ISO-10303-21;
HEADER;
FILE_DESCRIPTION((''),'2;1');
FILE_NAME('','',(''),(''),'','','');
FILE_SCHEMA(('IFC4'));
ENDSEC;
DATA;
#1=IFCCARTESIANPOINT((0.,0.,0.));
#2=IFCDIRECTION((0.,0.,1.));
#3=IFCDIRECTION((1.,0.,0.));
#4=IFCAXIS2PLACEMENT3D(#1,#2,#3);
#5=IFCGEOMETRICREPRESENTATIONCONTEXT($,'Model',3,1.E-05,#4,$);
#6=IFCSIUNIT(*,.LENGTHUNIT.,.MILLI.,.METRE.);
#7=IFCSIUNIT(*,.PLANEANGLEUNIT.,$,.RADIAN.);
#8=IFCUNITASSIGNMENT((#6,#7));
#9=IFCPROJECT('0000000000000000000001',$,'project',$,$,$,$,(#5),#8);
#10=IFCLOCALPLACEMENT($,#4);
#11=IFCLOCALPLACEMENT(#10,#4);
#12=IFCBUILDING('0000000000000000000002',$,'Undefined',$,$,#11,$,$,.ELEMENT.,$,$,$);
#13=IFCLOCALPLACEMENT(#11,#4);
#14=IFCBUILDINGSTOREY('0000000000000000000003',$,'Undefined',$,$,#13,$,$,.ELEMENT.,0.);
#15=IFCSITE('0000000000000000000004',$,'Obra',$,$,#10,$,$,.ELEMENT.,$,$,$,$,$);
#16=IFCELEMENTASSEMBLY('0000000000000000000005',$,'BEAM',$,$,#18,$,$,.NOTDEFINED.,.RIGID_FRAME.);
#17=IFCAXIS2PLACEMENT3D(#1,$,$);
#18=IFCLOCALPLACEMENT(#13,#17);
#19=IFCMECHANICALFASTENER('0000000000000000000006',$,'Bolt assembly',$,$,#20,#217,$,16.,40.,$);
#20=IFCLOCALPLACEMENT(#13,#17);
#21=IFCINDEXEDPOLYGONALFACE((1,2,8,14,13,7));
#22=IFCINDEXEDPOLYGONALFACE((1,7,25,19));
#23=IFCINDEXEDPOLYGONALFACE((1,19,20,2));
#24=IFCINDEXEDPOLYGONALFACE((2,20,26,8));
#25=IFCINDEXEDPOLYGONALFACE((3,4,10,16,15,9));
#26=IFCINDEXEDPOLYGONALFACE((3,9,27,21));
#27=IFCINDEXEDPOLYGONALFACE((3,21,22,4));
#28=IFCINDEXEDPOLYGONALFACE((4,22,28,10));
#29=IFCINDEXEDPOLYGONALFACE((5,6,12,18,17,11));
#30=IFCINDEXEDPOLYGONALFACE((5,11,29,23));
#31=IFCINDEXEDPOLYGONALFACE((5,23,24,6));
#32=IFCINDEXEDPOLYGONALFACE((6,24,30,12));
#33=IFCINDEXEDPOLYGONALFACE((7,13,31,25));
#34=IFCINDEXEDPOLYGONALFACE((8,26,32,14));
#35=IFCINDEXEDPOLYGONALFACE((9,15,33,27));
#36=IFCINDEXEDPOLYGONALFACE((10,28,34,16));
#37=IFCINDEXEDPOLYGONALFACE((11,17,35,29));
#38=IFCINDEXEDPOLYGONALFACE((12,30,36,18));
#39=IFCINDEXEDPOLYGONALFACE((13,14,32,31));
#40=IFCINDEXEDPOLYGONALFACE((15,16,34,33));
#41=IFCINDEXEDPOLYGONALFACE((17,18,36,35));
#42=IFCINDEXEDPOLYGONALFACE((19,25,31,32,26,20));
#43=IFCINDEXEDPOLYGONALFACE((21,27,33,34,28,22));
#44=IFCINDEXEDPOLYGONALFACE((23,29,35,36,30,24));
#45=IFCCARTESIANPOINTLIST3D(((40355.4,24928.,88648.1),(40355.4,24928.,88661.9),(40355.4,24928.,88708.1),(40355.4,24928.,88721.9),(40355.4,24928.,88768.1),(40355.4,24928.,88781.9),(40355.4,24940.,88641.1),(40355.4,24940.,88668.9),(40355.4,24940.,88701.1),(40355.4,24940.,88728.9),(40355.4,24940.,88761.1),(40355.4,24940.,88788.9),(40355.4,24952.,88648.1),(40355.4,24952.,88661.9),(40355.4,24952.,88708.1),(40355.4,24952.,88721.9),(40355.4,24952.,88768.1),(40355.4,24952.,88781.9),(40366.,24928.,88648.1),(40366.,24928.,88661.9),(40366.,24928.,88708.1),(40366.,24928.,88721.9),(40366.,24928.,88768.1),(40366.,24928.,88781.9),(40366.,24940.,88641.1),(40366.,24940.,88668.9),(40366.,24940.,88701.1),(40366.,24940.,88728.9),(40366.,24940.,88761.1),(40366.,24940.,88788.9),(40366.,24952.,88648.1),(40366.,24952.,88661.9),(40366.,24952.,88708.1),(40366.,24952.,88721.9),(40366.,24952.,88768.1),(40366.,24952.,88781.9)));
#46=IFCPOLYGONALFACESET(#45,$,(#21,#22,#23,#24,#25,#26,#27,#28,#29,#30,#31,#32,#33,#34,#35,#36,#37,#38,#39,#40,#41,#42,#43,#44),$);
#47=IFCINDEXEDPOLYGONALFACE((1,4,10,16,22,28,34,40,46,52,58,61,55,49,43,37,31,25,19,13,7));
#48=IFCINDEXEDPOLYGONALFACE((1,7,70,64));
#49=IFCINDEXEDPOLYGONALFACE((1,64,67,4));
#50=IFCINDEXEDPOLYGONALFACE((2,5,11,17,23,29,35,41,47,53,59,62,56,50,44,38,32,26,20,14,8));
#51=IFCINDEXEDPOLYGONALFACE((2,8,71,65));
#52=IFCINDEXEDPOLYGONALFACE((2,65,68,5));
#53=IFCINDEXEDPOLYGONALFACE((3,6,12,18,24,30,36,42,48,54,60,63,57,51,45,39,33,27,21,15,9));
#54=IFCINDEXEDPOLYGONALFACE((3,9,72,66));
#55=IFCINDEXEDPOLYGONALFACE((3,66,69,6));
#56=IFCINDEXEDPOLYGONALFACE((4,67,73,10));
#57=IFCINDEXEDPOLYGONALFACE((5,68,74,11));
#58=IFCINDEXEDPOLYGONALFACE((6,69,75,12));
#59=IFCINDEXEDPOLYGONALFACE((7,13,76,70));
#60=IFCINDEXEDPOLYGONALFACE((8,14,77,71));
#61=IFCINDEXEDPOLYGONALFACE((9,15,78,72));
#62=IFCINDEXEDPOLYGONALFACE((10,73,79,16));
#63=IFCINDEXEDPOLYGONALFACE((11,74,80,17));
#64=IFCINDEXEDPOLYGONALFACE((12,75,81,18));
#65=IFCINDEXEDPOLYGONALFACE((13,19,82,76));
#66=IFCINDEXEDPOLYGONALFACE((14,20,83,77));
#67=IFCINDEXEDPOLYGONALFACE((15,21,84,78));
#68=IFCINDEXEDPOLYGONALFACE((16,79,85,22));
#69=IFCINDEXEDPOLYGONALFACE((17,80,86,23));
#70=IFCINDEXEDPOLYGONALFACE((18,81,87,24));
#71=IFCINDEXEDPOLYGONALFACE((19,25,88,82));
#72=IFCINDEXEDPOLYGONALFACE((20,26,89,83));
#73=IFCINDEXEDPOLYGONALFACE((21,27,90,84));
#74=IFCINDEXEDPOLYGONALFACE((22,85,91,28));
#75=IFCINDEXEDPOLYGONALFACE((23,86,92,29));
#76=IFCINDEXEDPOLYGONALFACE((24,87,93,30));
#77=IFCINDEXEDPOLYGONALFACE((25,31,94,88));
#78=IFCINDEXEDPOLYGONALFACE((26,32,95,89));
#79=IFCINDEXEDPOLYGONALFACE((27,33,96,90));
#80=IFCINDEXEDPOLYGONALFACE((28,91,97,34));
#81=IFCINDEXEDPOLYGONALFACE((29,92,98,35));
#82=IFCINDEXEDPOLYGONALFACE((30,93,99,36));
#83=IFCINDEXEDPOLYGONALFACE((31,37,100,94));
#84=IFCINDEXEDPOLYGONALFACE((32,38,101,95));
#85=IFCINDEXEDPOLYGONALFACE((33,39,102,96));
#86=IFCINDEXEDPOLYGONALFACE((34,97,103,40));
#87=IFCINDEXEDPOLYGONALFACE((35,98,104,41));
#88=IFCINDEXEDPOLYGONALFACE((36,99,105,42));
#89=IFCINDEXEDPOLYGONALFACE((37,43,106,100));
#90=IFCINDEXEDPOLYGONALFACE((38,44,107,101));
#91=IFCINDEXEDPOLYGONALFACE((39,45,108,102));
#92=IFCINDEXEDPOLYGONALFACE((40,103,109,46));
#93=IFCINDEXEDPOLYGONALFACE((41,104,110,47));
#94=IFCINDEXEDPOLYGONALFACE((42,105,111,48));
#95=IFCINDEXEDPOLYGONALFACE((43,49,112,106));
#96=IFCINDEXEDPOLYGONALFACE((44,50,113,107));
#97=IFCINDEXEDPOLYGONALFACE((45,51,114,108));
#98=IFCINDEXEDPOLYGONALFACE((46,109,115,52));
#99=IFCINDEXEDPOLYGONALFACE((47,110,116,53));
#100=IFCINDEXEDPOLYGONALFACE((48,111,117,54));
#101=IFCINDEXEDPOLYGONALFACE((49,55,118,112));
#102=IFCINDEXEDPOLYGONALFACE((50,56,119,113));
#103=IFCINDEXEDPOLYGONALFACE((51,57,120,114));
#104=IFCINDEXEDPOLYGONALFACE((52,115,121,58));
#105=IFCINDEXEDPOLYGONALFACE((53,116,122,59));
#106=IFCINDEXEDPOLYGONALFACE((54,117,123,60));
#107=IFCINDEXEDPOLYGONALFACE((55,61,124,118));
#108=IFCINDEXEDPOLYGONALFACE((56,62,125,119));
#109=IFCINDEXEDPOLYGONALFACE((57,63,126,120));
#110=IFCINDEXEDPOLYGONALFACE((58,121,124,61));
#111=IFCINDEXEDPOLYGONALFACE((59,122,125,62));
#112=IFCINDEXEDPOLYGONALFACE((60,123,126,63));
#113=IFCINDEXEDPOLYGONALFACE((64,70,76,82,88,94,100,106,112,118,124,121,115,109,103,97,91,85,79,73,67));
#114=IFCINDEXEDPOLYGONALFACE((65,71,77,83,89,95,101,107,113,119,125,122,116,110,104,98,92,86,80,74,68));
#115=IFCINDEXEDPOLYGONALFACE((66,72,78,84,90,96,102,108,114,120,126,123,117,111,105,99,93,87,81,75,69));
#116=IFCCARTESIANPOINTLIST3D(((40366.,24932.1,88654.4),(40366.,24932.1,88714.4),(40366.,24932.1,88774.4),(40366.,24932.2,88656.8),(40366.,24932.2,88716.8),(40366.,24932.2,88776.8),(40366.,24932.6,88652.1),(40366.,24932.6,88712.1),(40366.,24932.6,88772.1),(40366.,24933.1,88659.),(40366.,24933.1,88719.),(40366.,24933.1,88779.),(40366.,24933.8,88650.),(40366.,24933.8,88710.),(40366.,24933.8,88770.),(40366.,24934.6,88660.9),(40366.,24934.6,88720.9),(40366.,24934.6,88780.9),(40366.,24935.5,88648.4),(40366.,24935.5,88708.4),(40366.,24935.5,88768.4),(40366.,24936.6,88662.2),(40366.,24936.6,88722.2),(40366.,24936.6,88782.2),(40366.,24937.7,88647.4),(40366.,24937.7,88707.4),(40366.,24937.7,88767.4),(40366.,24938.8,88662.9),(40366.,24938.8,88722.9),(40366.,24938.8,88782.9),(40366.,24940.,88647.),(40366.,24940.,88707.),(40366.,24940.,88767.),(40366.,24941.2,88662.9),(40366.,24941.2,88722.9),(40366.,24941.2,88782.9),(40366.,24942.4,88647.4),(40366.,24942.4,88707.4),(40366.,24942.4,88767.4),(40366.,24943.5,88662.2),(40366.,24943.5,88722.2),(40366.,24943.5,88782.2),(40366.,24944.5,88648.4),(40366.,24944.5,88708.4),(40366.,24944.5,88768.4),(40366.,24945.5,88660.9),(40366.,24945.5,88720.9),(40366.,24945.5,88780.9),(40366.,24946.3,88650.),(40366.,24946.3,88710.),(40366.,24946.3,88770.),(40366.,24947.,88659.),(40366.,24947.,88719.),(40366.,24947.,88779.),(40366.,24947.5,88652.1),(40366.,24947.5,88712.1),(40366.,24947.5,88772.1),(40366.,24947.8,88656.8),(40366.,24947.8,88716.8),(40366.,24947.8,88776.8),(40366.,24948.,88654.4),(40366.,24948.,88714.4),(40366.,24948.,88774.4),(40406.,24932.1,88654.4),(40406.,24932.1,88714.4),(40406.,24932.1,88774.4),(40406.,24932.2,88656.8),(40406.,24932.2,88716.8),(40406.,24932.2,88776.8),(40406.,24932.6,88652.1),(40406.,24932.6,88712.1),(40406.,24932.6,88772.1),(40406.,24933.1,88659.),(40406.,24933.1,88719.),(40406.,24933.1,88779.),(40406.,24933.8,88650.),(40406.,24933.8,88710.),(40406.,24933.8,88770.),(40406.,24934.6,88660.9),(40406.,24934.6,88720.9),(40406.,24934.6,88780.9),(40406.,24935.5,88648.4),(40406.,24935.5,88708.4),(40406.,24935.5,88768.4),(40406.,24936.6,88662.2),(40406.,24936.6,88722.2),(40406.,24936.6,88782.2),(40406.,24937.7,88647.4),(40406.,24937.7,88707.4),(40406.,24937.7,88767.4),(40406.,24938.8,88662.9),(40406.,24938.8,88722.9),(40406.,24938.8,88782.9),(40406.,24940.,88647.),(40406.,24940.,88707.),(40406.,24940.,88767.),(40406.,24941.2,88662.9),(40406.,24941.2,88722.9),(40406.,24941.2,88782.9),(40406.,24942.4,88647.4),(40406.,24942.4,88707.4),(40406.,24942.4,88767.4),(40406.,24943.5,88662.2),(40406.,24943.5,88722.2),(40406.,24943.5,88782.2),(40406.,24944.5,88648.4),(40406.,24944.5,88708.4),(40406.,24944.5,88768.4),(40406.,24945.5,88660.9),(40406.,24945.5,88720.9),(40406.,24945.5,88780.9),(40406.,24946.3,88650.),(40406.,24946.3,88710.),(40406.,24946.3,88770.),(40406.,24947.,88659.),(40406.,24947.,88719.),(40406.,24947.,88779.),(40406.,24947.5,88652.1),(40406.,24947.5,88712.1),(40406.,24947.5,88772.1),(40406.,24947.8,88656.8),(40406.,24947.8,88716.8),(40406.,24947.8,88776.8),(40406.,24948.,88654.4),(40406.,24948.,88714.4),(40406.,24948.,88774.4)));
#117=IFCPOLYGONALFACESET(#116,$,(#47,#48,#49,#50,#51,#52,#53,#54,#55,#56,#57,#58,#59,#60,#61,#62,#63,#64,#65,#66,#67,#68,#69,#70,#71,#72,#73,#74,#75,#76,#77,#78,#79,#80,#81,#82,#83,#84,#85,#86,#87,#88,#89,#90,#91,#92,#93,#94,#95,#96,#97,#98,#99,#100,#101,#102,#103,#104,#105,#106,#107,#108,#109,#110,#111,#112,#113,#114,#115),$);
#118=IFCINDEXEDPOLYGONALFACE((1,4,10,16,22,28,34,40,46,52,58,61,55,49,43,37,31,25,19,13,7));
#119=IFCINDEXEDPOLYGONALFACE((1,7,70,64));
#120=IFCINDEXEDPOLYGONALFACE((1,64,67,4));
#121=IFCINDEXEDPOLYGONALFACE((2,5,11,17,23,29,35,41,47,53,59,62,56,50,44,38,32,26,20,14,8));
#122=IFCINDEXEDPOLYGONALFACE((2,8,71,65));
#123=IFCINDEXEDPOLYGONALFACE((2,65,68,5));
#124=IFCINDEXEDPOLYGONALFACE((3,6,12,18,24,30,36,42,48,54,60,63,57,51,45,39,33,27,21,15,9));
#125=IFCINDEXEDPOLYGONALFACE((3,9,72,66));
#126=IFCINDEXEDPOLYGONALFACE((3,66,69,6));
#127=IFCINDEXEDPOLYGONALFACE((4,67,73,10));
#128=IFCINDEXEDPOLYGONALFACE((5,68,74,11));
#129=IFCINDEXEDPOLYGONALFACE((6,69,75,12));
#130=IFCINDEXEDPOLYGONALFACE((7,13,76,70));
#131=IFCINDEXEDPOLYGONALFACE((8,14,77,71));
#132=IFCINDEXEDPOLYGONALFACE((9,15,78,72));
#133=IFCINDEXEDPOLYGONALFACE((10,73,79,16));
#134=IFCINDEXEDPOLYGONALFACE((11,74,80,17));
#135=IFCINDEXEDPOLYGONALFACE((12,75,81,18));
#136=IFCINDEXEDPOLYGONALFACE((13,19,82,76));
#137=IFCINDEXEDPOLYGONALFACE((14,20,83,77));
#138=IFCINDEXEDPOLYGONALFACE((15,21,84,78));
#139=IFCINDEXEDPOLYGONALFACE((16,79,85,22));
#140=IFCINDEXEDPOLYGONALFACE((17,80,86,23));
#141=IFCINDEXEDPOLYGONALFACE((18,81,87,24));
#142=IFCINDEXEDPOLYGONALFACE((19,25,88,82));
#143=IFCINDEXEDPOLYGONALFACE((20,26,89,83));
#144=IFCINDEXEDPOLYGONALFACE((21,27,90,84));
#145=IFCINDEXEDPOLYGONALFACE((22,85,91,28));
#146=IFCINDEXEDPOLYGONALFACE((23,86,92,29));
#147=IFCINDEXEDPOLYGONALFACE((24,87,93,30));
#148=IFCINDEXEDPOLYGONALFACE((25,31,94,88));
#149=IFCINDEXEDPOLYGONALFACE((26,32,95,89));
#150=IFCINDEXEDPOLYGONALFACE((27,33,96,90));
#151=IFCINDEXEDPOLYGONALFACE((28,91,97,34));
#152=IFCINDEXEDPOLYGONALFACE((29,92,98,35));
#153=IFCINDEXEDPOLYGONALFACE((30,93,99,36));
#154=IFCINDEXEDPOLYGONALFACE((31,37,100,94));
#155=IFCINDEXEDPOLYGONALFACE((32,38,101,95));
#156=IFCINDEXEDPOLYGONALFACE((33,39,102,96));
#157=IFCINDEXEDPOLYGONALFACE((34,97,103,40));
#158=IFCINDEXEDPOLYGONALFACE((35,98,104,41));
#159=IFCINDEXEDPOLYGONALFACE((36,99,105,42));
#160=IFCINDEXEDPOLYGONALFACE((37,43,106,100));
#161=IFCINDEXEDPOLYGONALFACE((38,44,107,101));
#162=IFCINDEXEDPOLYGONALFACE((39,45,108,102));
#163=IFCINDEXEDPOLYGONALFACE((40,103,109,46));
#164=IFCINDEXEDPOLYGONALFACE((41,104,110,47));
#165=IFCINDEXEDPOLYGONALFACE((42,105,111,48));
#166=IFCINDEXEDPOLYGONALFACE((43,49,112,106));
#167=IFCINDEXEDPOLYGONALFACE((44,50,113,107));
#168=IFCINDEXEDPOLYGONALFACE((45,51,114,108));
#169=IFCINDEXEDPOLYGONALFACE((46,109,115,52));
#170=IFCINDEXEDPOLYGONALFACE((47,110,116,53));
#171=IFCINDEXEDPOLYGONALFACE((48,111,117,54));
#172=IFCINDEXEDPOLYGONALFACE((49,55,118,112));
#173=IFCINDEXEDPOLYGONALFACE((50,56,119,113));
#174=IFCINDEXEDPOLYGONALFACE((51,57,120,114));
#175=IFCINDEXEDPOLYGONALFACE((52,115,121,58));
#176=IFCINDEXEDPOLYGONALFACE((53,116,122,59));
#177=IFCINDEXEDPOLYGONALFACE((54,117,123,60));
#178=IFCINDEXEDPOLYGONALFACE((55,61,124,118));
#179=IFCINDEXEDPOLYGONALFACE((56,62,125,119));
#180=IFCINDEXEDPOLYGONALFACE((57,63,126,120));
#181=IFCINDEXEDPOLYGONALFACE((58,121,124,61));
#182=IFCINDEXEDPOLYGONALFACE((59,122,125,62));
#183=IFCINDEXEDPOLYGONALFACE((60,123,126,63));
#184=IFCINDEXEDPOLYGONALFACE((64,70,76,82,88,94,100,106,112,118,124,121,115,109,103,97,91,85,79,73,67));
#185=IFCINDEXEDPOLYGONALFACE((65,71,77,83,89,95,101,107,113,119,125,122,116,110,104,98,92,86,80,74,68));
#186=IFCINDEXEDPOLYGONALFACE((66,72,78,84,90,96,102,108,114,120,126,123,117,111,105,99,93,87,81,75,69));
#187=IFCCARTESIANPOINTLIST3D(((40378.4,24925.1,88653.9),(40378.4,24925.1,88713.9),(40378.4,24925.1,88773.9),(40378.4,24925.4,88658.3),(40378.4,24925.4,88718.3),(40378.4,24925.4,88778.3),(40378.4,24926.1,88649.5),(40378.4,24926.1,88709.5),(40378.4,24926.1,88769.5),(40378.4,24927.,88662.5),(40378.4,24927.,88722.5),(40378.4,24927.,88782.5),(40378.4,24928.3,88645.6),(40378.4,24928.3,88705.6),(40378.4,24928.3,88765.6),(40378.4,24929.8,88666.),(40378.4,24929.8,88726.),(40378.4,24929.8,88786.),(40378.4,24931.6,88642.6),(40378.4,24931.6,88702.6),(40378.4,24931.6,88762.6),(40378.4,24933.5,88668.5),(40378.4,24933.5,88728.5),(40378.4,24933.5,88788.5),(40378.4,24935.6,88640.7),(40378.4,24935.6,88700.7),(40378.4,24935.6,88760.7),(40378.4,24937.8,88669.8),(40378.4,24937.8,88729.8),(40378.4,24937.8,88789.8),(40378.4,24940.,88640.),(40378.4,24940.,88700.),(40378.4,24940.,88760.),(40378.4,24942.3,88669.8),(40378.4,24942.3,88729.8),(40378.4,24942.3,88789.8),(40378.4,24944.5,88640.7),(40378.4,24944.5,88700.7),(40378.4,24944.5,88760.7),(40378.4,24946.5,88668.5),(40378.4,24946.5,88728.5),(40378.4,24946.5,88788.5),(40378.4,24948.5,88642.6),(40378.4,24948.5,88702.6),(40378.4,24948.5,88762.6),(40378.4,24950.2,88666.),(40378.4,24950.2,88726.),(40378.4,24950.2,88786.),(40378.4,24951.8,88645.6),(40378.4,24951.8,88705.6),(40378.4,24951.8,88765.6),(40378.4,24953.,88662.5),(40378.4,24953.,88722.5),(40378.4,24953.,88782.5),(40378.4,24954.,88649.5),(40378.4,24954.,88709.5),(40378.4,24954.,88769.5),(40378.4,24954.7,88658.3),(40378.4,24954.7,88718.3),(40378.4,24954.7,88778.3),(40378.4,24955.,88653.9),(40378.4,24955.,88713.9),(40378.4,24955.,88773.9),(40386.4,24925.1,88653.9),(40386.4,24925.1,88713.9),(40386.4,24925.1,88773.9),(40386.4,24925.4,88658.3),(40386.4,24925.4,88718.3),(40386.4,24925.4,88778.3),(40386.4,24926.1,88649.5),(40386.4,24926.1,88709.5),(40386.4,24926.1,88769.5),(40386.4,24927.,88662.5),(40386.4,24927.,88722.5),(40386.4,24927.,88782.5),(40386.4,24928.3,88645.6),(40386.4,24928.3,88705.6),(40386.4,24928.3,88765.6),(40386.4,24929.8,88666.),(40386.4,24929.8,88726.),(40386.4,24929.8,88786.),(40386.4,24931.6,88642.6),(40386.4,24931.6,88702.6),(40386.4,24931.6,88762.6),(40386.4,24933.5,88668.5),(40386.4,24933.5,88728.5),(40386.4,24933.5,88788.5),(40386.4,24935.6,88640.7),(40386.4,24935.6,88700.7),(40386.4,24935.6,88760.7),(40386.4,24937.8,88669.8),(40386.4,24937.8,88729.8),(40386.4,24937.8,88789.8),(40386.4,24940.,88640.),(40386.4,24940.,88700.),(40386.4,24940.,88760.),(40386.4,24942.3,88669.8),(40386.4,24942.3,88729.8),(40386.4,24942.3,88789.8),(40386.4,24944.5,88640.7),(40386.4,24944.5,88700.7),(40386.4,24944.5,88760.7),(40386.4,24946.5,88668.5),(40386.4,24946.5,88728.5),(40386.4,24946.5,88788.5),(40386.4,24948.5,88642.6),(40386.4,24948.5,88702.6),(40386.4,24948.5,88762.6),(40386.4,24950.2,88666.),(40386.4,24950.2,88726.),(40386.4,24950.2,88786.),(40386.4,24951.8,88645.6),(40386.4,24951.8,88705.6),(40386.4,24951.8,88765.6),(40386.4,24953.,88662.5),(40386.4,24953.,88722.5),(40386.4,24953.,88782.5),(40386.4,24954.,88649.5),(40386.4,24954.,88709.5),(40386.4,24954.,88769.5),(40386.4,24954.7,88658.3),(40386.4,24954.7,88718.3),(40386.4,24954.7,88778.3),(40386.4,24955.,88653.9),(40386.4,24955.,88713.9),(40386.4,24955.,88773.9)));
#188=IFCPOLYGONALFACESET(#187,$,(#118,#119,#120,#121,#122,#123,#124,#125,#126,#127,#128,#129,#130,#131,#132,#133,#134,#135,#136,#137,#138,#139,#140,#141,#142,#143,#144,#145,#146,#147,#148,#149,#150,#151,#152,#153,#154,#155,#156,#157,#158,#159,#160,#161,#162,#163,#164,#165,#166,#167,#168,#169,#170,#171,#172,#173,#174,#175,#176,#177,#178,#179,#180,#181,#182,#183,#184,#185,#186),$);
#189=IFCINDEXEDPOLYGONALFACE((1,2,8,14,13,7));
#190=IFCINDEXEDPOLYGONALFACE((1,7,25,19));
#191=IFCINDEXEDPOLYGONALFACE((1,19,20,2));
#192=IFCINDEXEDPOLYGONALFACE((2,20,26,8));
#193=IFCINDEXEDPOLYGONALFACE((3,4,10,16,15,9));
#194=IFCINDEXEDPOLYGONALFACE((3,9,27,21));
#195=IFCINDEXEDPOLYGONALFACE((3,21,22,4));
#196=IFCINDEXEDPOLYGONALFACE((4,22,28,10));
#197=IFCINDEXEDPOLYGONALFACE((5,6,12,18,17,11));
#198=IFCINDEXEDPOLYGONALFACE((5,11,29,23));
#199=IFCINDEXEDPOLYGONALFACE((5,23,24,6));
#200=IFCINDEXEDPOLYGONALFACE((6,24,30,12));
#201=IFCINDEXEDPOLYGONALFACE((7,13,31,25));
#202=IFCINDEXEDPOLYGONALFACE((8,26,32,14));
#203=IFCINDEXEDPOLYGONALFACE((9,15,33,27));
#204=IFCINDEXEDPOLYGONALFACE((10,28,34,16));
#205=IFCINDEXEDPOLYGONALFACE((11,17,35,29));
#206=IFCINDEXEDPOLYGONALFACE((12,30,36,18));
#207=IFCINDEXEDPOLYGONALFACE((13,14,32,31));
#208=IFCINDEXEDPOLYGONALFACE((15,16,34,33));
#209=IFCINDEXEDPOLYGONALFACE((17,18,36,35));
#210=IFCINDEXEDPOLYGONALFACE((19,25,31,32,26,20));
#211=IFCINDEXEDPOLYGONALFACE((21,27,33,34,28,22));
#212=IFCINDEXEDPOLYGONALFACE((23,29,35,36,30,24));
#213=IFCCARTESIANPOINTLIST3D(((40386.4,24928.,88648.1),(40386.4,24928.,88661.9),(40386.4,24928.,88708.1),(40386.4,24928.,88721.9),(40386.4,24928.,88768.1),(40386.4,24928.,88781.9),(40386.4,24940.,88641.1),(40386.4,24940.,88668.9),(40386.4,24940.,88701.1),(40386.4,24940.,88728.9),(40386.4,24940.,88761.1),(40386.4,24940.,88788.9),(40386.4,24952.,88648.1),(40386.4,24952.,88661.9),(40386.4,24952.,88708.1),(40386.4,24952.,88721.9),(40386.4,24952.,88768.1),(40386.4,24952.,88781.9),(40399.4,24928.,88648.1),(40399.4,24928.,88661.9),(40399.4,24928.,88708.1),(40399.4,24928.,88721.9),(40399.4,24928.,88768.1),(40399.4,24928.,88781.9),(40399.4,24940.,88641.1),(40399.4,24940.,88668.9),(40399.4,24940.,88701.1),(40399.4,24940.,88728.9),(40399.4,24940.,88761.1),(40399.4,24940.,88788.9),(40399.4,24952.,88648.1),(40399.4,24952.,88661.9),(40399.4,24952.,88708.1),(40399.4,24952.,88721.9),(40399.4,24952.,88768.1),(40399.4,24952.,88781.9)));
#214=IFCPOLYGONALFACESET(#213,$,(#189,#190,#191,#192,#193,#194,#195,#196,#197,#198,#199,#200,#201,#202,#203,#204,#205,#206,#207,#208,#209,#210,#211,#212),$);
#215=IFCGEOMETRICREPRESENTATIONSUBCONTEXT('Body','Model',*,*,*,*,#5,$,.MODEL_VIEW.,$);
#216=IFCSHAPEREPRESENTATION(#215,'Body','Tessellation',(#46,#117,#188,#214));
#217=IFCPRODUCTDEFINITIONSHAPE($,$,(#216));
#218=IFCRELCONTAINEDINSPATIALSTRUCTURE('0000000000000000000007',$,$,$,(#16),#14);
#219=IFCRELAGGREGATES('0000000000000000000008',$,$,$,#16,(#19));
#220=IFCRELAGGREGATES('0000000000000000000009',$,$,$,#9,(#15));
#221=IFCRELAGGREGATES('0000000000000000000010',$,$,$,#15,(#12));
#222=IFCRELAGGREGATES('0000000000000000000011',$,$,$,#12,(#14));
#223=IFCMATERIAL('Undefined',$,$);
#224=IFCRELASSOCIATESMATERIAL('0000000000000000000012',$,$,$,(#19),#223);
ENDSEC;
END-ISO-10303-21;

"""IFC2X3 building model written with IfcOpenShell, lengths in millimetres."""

from ifc_helpers import new_model, si_unit, frame, origin_with_axes, origin_2d_with_axis, place, context, subcontext, project, spatial, polyline, circle, outline, extrude, source, transform, mapped, material, element, aggregate, save


model = new_model("IFC2X3")

# Units and contexts
model_context = context("Model", 3, precision=1e-05, world=origin_with_axes())
body_context = subcontext(model_context, "Body", "Model", "MODEL_VIEW")
ifc_project = project(units=[si_unit("LENGTHUNIT", "METRE", prefix="MILLI"), si_unit("PLANEANGLEUNIT", "RADIAN")], contexts=[model_context])

# Site, building, storey
site_placement = place(None, origin_with_axes())
site = spatial("IfcSite", under=ifc_project, at=site_placement, Name="Obra", CompositionType="ELEMENT")
building_placement = place(site_placement, origin_with_axes())
building = spatial("IfcBuilding", under=site, at=building_placement, Name="Undefined", CompositionType="ELEMENT")
storey_placement = place(building_placement, origin_with_axes())
storey = spatial("IfcBuildingStorey", under=building, at=storey_placement, Name="Undefined", CompositionType="ELEMENT", Elevation=0.0)

# Element assembly
ifc_material_1 = material(Name="Undefined")
assembly_1_placement = place(storey_placement, origin_with_axes())
assembly_1 = element("IfcElementAssembly", 1, at=assembly_1_placement, inside=storey, Name="BEAM", AssemblyPlace="NOTDEFINED", PredefinedType="RIGID_FRAME")
shared_shape_1 = source(origin_with_axes(), body_context, "Body", "SweptSolid", [
    extrude(outline(polyline([(13.9, 0.0), (6.9, 12.0), (-6.9, 12.0), (-13.9, 0.0), (-6.9, -12.0), (6.9, -12.0), (13.9, 0.0)])), frame((0.0, -19.7, 0.0), z_axis=(0.0, 1.0, 0.0), x_axis=(1.0, 0.0, 0.0)), (0.0, 0.0, 1.0), 10.6),
    extrude(circle(Radius=8.0, at=origin_2d_with_axis()), frame((0.0, -9.1, 0.0), z_axis=(0.0, 1.0, 0.0), x_axis=(1.0, 0.0, 0.0)), (0.0, 0.0, 1.0), 40.0),
    extrude(circle(Radius=15.0, at=origin_2d_with_axis()), frame((0.0, 3.3, 0.0), z_axis=(0.0, 1.0, 0.0), x_axis=(1.0, 0.0, 0.0)), (0.0, 0.0, 1.0), 8.0),
    extrude(outline(polyline([(13.9, 0.0), (6.9, 12.0), (-6.9, 12.0), (-13.9, 0.0), (-6.9, -12.0), (6.9, -12.0), (13.9, 0.0)])), frame((0.0, 11.3, 0.0), z_axis=(0.0, 1.0, 0.0), x_axis=(1.0, 0.0, 0.0)), (0.0, 0.0, 1.0), 13.0),
])

# Mechanical fastener
mechanical_fastener_1_placement = place(assembly_1_placement, frame((40375.1, 24990.0, 88835.0), z_axis=(0.000002, -1.0, 0.0), x_axis=(0.0, 0.0, -1.0)))
mechanical_fastener_1 = element("IfcMechanicalFastener", 2, at=mechanical_fastener_1_placement, material=ifc_material_1, Name="Bolt assembly", NominalDiameter=16.0, NominalLength=40.0, context=body_context, shape_type="MappedRepresentation", body=[
    mapped(shared_shape_1, transform((60.0, 0.0, 50.0))),
    mapped(shared_shape_1, transform((120.0, 0.0, 50.0))),
    mapped(shared_shape_1, transform((180.0, 0.0, 50.0))),
])
aggregate(assembly_1, [mechanical_fastener_1])

save(model, "model.ifc")
